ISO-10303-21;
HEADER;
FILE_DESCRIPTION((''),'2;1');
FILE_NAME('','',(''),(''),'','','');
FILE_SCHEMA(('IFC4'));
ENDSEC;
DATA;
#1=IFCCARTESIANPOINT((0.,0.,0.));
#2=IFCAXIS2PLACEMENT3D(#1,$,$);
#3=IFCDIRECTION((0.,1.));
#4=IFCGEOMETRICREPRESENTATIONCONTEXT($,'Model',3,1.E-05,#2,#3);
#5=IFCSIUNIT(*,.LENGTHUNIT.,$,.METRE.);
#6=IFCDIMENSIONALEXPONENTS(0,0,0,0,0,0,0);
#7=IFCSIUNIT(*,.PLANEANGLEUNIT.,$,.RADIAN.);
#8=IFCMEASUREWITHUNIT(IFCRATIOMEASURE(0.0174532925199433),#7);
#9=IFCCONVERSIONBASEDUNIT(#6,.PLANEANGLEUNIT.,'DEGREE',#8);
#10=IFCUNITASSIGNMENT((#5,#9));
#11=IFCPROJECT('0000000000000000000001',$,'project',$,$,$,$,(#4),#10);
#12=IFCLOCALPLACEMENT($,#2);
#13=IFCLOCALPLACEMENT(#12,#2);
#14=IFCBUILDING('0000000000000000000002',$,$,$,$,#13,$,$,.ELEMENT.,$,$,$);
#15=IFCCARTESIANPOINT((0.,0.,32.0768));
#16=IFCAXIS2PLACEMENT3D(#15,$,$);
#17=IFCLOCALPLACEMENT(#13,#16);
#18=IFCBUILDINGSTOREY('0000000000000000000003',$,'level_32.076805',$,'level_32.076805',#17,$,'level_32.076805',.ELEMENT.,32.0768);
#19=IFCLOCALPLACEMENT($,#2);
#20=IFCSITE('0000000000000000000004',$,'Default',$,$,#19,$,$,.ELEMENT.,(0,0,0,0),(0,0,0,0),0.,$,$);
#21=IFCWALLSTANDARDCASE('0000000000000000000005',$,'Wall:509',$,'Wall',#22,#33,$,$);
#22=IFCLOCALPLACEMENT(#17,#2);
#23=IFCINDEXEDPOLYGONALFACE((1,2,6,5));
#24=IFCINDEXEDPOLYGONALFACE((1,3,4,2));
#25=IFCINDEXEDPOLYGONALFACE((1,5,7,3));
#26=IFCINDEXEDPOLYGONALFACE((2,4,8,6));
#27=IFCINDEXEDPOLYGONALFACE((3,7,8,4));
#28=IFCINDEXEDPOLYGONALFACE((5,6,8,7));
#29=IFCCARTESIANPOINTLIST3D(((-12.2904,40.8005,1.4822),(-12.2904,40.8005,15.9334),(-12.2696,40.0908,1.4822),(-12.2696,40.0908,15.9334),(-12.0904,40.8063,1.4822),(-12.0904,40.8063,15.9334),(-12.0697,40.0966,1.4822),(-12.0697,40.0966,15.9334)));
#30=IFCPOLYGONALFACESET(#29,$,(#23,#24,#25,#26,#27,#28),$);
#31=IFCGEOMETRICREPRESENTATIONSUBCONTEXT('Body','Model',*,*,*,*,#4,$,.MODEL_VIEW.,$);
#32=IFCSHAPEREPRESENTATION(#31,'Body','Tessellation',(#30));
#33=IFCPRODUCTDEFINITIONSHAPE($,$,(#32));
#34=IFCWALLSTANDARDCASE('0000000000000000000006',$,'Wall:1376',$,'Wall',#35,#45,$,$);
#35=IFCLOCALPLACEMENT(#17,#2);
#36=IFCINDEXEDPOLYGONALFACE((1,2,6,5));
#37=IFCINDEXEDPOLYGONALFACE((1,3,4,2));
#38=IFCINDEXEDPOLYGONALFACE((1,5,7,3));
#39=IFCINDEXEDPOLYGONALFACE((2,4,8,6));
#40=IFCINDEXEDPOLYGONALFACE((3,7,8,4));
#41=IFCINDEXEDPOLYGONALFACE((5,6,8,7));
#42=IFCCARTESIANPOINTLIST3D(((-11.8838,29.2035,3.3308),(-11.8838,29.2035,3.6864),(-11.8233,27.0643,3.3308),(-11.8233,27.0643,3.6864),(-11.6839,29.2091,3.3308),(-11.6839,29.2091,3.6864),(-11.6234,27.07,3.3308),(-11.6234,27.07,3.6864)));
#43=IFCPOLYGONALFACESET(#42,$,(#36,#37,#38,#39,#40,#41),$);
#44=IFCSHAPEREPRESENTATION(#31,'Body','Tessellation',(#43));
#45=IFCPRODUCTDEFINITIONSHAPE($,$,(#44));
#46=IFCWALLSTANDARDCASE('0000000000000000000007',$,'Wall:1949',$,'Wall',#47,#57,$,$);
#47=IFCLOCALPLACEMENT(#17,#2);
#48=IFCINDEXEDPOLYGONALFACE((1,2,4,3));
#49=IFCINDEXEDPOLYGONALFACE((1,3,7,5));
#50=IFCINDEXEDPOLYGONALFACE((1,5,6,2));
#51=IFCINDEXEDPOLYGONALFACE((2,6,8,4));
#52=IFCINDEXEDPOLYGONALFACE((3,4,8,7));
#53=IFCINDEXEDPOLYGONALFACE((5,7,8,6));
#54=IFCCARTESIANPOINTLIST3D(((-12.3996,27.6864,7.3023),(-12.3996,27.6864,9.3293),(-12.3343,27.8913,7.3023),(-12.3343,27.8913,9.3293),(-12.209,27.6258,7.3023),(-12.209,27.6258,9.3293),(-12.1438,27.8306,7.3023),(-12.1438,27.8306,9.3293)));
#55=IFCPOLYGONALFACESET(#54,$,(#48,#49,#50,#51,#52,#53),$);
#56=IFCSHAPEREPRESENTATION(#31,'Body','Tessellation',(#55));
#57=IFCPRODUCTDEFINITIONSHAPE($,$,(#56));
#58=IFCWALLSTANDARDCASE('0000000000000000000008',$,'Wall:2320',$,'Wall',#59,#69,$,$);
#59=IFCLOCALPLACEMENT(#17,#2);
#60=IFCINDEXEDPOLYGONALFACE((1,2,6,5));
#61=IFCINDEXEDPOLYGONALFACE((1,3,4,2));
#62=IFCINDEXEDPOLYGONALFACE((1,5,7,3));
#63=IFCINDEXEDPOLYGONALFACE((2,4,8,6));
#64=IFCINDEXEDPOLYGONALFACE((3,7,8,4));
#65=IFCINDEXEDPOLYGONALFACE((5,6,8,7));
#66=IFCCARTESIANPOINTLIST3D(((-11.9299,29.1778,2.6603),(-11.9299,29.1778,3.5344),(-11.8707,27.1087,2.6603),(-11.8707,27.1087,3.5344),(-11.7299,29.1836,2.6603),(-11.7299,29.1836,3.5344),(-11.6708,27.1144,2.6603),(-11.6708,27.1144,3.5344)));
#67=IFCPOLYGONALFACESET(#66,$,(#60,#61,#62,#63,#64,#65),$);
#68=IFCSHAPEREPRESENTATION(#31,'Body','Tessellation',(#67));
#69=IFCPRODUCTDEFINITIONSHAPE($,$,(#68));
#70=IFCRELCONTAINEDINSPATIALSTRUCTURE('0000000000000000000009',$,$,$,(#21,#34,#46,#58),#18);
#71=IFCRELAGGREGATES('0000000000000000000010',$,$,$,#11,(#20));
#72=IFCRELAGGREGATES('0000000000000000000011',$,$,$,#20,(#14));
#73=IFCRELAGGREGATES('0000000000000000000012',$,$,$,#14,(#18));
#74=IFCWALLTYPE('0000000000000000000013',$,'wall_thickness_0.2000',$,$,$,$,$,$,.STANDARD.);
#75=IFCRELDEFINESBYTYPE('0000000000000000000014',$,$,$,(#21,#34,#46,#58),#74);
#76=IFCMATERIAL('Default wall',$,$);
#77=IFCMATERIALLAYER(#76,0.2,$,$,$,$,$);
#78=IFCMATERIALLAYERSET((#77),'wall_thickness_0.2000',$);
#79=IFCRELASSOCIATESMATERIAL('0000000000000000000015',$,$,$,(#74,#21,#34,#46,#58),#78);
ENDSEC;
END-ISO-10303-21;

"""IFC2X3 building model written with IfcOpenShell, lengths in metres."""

from ifc_helpers import new_model, entity, si_unit, converted_unit, direction, frame, origin, place, context, subcontext, project, spatial, polyline, outline, extrude, material, layer, layer_set, layer_usage, type_object, element, save


model = new_model("IFC2X3")

# Units and contexts
model_context = context("Model", 3, precision=1e-05, world=origin(), true_north=direction((0.0, 1.0)))
body_context = subcontext(model_context, "Body", "Model", "MODEL_VIEW")
ifc_project = project(units=[si_unit("LENGTHUNIT", "METRE"), converted_unit("PLANEANGLEUNIT", "DEGREE", entity("IfcRatioMeasure", 0.0174532925199433), si_unit("PLANEANGLEUNIT", "RADIAN"), dimensions=[0, 0, 0, 0, 0, 0, 0])], contexts=[model_context])

# Site, building, storey
site_placement = place(None, origin())
site = spatial("IfcSite", under=ifc_project, at=site_placement, Name="Default", CompositionType="ELEMENT", RefLatitude=(0, 0, 0, 0), RefLongitude=(0, 0, 0, 0), RefElevation=0.0)
placement_1 = place(None, origin())
building_placement = place(placement_1, origin())
building = spatial("IfcBuilding", under=site, at=building_placement, CompositionType="ELEMENT")
storey_placement = place(building_placement, frame((0.0, 0.0, 32.0768)))
storey = spatial("IfcBuildingStorey", under=building, at=storey_placement, Name="level_32.076805", ObjectType="level_32.076805", LongName="level_32.076805", CompositionType="ELEMENT", Elevation=32.0768)

# Walls
ifc_material = material(Name="Default wall")
ifc_layer = layer(ifc_material, 0.2)
ifc_layer_set = layer_set([ifc_layer], Name="wall_thickness_0.2000")
ifc_layer_usage = layer_usage(ifc_layer_set, "AXIS2", "POSITIVE", -0.1)
wall_type = type_object("IfcWallType", Name="wall_thickness_0.2000", PredefinedType="STANDARD", material=ifc_layer_set)
placement_2 = place(building_placement, frame((0.0, 0.0, 33.559)))
wall_1_placement = place(placement_2, frame((-12.1696, 40.0937, 0.0), z_axis=(0.0, 0.0, 1.0), x_axis=(-0.029235, 0.999573, 0.0)))
element("IfcWallStandardCase", 1, at=wall_1_placement, inside=storey, type_object=wall_type, material=ifc_layer_usage, Name="Wall:509", ObjectType="Wall", context=body_context, shape_type="SweptSolid", body=[
    extrude(outline(polyline([(0.71, -0.1), (0.71, 0.1), (0.0, 0.1), (0.0, -0.1), (0.71, -0.1)])), origin(), (0.0, 0.0, 1.0), 14.4512),
])
placement_3 = place(building_placement, frame((0.0, 0.0, 35.4076)))
wall_2_placement = place(placement_3, frame((-11.7838, 29.2063, 0.0), z_axis=(0.0, 0.0, 1.0), x_axis=(0.028277, -0.9996, 0.0)))
element("IfcWallStandardCase", 2, at=wall_2_placement, inside=storey, type_object=wall_type, material=ifc_layer_usage, Name="Wall:1376", ObjectType="Wall", context=body_context, shape_type="SweptSolid", body=[
    extrude(outline(polyline([(2.14, -0.1), (2.14, 0.1), (0.0, 0.1), (0.0, -0.1), (2.14, -0.1)])), origin(), (0.0, 0.0, 1.0), 0.3555),
])
placement_4 = place(building_placement, frame((0.0, 0.0, 39.3791)))
wall_3_placement = place(placement_4, frame((-12.3043, 27.6561, 0.0), z_axis=(0.0, 0.0, 1.0), x_axis=(0.303408, 0.952861, 0.0)))
element("IfcWallStandardCase", 3, at=wall_3_placement, inside=storey, type_object=wall_type, material=ifc_layer_usage, Name="Wall:1949", ObjectType="Wall", context=body_context, shape_type="SweptSolid", body=[
    extrude(outline(polyline([(0.215, -0.1), (0.215, 0.1), (0.0, 0.1), (0.0, -0.1), (0.215, -0.1)])), origin(), (0.0, 0.0, 1.0), 2.027),
])
placement_5 = place(building_placement, frame((0.0, 0.0, 34.7371)))
wall_4_placement = place(placement_5, frame((-11.7707, 27.1115, 0.0), z_axis=(0.0, 0.0, 1.0), x_axis=(-0.028594, 0.999591, 0.0)))
element("IfcWallStandardCase", 4, at=wall_4_placement, inside=storey, type_object=wall_type, material=ifc_layer_usage, Name="Wall:2320", ObjectType="Wall", context=body_context, shape_type="SweptSolid", body=[
    extrude(outline(polyline([(2.07, -0.1), (2.07, 0.1), (0.0, 0.1), (0.0, -0.1), (2.07, -0.1)])), origin(), (0.0, 0.0, 1.0), 0.8741),
])

save(model, "model.ifc")
